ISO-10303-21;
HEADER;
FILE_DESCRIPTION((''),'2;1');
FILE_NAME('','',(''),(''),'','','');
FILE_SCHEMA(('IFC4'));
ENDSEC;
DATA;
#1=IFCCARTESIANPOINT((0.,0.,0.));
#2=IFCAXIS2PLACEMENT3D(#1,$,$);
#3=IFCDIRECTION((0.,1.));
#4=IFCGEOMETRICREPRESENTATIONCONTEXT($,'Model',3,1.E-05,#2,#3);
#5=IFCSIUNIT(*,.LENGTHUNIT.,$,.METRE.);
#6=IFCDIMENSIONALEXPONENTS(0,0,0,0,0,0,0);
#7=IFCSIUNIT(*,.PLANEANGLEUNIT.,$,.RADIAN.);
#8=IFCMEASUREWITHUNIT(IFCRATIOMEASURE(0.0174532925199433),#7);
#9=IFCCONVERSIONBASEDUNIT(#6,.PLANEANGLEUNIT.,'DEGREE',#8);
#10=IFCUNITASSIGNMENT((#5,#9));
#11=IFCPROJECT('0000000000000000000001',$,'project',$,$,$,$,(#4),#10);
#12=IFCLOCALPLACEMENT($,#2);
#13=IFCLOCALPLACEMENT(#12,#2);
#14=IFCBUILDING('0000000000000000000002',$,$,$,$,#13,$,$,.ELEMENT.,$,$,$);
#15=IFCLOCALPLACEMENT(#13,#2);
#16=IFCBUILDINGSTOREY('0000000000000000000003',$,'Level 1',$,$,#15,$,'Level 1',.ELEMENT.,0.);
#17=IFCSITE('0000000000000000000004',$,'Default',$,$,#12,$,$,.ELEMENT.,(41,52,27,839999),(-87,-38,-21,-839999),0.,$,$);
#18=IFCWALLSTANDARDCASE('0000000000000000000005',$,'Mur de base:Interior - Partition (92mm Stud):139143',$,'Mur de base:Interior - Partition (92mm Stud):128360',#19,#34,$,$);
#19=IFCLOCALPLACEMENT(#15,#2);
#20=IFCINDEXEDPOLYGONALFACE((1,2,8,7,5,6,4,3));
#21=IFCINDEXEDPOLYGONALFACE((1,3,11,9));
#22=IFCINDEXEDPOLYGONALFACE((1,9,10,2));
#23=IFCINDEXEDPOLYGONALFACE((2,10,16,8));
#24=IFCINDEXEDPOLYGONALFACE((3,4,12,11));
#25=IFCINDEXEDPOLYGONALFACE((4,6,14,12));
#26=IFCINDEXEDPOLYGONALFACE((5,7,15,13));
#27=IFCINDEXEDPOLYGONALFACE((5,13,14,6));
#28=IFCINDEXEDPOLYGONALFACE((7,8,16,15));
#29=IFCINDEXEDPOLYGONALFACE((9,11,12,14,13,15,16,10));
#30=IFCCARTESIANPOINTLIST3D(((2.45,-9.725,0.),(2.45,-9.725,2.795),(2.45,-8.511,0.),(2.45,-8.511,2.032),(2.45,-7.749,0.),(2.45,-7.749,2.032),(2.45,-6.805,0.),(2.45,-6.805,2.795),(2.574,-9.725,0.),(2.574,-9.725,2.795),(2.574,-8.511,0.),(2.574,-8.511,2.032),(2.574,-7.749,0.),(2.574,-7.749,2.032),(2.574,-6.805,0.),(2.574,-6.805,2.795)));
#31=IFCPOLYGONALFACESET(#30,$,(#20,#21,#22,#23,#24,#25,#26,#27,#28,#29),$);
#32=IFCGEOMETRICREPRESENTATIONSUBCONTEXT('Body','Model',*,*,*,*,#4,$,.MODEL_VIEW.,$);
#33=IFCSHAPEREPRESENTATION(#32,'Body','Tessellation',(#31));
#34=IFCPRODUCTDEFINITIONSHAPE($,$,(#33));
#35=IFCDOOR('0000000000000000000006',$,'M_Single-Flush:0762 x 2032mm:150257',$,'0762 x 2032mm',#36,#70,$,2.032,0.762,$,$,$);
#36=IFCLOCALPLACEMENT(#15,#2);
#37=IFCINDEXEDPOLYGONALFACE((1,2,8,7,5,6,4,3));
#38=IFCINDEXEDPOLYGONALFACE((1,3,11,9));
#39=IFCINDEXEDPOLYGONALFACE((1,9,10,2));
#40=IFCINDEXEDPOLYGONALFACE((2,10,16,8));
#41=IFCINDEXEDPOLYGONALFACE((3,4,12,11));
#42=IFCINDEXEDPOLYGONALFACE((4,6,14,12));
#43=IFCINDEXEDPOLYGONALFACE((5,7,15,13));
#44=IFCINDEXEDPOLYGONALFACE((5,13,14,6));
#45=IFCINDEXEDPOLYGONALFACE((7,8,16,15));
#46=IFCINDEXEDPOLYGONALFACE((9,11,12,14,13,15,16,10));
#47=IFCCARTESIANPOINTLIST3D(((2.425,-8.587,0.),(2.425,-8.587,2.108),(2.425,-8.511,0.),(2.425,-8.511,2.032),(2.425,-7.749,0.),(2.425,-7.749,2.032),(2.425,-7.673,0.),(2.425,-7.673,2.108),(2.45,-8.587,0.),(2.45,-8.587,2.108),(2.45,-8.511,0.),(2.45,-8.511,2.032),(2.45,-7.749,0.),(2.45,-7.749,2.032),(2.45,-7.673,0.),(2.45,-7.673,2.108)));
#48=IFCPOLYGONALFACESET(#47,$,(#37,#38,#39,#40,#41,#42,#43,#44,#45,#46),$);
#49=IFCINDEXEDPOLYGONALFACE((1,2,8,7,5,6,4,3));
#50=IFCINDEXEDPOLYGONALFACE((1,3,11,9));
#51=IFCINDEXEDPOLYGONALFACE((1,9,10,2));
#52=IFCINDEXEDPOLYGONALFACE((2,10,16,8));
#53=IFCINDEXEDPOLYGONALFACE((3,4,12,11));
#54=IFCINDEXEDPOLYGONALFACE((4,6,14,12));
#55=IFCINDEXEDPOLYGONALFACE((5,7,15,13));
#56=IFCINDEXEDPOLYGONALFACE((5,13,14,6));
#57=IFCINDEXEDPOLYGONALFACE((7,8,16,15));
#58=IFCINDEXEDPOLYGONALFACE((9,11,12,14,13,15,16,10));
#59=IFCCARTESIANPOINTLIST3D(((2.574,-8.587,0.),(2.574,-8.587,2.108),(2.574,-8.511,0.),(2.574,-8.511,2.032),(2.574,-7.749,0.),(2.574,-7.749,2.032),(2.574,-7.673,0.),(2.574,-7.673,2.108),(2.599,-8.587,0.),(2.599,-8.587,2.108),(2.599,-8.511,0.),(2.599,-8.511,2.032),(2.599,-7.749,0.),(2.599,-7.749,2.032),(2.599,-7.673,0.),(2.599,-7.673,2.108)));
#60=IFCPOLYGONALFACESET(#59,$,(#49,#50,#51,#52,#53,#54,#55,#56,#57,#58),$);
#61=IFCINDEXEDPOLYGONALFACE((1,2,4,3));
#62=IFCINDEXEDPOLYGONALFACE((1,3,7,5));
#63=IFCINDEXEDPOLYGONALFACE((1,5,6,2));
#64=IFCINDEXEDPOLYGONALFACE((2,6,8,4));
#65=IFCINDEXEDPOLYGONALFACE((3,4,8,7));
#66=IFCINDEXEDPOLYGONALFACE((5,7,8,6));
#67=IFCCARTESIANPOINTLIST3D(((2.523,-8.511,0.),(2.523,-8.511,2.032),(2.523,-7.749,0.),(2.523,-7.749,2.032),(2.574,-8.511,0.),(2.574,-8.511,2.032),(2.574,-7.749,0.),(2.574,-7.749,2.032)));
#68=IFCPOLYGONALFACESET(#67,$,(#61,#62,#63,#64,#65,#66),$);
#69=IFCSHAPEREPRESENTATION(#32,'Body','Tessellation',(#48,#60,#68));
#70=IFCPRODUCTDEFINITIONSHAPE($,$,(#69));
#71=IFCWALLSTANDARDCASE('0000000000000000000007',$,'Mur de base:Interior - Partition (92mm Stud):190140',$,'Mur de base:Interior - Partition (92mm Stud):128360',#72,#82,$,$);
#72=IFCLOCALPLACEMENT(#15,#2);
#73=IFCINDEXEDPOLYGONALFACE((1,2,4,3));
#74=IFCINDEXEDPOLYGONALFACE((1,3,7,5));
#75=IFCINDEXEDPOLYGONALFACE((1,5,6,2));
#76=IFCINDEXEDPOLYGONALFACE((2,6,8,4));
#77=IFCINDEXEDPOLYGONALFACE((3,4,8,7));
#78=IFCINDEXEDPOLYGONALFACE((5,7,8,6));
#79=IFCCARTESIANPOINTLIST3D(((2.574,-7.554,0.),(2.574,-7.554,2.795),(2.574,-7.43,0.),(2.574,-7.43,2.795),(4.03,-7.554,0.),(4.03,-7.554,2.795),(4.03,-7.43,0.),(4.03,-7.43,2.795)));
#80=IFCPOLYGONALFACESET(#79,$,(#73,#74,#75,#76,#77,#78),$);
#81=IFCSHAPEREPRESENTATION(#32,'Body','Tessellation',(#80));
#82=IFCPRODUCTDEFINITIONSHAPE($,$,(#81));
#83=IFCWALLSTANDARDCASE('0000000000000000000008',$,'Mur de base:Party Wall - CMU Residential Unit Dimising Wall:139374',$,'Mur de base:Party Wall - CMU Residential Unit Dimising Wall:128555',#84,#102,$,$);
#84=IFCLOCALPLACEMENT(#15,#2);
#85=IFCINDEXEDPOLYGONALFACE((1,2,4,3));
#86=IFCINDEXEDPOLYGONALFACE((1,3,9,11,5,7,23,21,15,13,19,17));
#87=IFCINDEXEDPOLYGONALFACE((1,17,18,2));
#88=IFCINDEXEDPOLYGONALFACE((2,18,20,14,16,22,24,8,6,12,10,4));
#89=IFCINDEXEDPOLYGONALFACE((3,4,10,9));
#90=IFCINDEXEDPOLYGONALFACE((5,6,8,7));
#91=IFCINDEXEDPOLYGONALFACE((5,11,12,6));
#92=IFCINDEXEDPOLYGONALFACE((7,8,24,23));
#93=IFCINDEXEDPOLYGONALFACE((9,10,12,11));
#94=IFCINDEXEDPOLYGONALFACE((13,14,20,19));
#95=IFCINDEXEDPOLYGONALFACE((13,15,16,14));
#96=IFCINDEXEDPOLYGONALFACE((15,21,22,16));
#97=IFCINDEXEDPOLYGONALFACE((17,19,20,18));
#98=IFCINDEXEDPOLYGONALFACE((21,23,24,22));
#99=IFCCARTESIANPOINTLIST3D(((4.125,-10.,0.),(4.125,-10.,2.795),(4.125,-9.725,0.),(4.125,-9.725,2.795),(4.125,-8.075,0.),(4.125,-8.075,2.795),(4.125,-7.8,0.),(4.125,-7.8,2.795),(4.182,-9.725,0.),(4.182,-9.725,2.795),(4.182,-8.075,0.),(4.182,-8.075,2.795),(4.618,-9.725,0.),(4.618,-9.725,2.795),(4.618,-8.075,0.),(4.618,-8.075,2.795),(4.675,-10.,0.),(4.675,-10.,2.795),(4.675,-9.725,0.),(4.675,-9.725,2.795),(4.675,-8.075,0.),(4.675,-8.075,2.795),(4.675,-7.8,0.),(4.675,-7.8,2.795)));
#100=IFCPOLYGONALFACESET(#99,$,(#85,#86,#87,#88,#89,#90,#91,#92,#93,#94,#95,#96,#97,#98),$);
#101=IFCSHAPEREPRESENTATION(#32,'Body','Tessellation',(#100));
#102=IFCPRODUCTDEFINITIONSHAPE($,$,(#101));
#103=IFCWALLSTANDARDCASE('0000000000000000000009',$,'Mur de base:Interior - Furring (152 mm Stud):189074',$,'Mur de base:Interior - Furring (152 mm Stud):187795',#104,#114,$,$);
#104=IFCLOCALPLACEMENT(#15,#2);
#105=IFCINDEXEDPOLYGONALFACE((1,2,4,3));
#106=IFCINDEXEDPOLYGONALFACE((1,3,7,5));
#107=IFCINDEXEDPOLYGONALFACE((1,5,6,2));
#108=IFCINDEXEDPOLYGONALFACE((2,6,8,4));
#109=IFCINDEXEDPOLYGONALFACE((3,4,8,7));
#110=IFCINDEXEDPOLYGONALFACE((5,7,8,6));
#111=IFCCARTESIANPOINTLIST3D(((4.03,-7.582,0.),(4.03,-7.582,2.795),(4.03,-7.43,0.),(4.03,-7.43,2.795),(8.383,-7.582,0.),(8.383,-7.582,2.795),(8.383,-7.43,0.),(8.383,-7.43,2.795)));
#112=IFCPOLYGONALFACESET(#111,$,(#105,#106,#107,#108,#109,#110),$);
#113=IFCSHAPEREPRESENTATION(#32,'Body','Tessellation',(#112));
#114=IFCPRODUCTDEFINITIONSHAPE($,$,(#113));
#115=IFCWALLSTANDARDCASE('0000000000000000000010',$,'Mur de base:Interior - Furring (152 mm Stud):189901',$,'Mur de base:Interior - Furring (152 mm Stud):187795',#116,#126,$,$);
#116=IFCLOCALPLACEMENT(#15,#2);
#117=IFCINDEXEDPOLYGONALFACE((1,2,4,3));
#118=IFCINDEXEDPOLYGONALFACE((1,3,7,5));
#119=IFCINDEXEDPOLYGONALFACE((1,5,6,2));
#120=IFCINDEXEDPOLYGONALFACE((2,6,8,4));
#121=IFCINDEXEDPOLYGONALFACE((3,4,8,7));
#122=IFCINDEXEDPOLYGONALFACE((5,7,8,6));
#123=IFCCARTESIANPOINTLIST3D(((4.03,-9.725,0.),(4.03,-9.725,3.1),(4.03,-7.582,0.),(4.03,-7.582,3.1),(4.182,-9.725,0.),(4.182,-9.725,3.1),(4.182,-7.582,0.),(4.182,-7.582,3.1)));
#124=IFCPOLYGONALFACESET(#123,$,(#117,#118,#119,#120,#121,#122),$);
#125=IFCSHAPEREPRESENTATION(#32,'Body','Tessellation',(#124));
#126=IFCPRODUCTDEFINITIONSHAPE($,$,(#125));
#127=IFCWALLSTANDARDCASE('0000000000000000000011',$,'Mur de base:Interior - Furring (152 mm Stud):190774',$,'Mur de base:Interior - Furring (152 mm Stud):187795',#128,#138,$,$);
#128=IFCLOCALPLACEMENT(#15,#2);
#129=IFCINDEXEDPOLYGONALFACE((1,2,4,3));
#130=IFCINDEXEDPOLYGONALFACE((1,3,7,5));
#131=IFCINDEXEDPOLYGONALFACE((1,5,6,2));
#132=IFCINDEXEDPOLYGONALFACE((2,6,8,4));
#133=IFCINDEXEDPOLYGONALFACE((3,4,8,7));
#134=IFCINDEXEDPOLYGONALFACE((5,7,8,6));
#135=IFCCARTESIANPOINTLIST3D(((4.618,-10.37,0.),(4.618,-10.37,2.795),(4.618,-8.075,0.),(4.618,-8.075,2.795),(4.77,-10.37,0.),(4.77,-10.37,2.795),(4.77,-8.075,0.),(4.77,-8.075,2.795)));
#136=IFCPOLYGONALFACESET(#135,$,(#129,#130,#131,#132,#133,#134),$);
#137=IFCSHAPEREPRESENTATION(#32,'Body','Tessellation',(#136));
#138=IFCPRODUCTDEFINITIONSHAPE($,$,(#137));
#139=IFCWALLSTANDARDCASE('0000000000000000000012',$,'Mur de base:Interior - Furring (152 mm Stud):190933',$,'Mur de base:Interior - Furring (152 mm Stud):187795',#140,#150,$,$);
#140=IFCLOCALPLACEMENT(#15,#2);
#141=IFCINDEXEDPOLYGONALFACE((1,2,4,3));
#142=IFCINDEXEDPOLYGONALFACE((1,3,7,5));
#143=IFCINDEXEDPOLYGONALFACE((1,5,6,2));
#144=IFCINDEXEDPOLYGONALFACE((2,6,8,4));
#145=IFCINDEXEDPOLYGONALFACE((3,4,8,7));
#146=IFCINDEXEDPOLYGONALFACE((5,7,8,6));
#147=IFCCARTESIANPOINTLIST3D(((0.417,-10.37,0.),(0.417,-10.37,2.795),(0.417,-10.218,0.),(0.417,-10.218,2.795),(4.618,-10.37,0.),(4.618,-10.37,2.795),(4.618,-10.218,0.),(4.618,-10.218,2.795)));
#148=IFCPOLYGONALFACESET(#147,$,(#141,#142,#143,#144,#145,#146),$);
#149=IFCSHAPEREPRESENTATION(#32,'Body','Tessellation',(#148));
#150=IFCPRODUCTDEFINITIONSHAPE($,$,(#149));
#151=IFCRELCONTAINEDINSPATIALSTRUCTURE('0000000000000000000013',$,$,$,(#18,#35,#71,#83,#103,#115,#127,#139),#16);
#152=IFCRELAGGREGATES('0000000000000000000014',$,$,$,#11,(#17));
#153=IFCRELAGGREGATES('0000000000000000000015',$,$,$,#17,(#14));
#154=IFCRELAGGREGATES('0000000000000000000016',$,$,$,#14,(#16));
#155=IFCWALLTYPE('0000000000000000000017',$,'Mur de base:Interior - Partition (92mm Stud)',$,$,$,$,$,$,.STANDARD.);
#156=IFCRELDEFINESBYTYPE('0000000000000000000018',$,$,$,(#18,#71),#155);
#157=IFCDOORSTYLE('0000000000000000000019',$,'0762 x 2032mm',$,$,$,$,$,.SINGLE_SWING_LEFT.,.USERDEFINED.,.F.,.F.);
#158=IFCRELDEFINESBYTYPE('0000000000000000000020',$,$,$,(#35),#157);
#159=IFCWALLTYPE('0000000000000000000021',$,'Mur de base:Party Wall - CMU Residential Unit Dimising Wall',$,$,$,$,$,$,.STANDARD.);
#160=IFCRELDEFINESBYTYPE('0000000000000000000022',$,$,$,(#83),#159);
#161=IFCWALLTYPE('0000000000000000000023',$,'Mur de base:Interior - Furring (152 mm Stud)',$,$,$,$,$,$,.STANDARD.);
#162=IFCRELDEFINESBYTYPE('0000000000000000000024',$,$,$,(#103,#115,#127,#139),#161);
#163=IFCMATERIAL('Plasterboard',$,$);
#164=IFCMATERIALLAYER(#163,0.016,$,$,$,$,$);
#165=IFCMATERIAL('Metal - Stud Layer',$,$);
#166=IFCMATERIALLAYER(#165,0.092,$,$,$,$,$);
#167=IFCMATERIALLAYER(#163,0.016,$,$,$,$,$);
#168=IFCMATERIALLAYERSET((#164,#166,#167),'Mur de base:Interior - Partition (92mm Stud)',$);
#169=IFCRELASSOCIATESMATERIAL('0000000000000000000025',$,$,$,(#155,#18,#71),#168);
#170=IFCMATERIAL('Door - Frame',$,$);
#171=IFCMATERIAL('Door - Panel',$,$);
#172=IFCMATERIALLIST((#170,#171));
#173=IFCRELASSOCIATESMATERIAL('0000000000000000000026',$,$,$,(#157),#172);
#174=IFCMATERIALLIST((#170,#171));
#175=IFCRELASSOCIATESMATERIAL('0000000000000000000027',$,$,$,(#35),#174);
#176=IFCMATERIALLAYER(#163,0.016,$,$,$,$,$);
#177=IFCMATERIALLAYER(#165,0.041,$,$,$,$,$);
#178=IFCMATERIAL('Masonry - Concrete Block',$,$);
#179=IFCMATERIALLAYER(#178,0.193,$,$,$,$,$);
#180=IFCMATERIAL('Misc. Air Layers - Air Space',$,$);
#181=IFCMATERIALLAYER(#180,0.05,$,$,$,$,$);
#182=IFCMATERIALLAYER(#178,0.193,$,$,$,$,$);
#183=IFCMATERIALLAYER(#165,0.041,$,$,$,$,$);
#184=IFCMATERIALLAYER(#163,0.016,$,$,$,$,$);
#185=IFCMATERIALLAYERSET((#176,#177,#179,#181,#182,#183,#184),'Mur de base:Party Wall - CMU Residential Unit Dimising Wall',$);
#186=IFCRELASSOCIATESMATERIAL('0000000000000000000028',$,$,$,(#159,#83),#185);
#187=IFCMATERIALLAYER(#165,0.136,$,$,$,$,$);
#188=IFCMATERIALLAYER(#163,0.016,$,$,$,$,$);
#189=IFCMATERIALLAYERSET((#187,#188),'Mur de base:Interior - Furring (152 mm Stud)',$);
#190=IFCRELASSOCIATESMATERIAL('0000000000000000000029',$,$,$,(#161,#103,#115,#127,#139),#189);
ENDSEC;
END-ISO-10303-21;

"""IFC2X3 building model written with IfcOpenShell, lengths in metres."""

from ifc_helpers import new_model, entity, si_unit, converted_unit, direction, frame, frame_2d, origin, place, context, subcontext, project, spatial, polyline, rectangle, outline, extrude, clip, bounded_halfspace, source, transform, mapped, material, material_list, layer, layer_set, layer_usage, type_object, type_shapes, element, fill, save


model = new_model("IFC2X3")

# Units and contexts
model_context = context("Model", 3, precision=1e-05, world=origin(), true_north=direction((0.0, 1.0)))
body_context = subcontext(model_context, "Body", "Model", "MODEL_VIEW")
ifc_project = project(units=[si_unit("LENGTHUNIT", "METRE"), converted_unit("PLANEANGLEUNIT", "DEGREE", entity("IfcRatioMeasure", 0.0174532925199433), si_unit("PLANEANGLEUNIT", "RADIAN"), dimensions=[0, 0, 0, 0, 0, 0, 0])], contexts=[model_context])

# Site, building, storey
site_placement = place(None, origin())
site = spatial("IfcSite", under=ifc_project, at=site_placement, Name="Default", CompositionType="ELEMENT", RefLatitude=(41, 52, 27, 839999), RefLongitude=(-87, -38, -21, -839999), RefElevation=0.0)
building_placement = place(site_placement, origin())
building = spatial("IfcBuilding", under=site, at=building_placement, CompositionType="ELEMENT")
storey_placement = place(building_placement, origin())
storey = spatial("IfcBuildingStorey", under=building, at=storey_placement, Name="Level 1", LongName="Level 1", CompositionType="ELEMENT", Elevation=0.0)

# Wall, opening, door
ifc_material_1 = material(Name="Plasterboard")
ifc_layer_1 = layer(ifc_material_1, 0.016)
ifc_material_2 = material(Name="Metal - Stud Layer")
ifc_layer_2 = layer(ifc_material_2, 0.092)
ifc_layer_3 = layer(ifc_material_1, 0.016)
ifc_layer_set_1 = layer_set([ifc_layer_1, ifc_layer_2, ifc_layer_3], Name="Mur de base:Interior - Partition (92mm Stud)")
ifc_layer_usage_1 = layer_usage(ifc_layer_set_1, "AXIS2", "NEGATIVE", 0.062)
wall_type_1 = type_object("IfcWallType", Name="Mur de base:Interior - Partition (92mm Stud)", PredefinedType="STANDARD", material=ifc_layer_set_1)
wall_1_placement = place(storey_placement, frame((2.512, -6.805, 0.0), z_axis=(0.0, 0.0, 1.0), x_axis=(0.0, -1.0, 0.0)))
wall_1 = element("IfcWallStandardCase", 1, at=wall_1_placement, inside=storey, type_object=wall_type_1, material=ifc_layer_usage_1, Name="Mur de base:Interior - Partition (92mm Stud):139143", ObjectType="Mur de base:Interior - Partition (92mm Stud):128360", context=body_context, shape_type="SweptSolid", body=[
    extrude(rectangle(XDim=2.92, YDim=0.124, at=frame_2d((1.46, 0.0), x_axis=(-1.0, 0.0))), origin(), (0.0, 0.0, 1.0), 2.795),
])
opening_1_placement = place(wall_1_placement, frame((0.944, -0.062, 0.0)))
opening_1 = element("IfcOpeningElement", 2, at=opening_1_placement, cuts=wall_1, ObjectType="Opening", context=body_context, shape_type="SweptSolid", body=[
    extrude(rectangle(XDim=0.762, YDim=2.032, at=frame_2d((1.016, 0.381), x_axis=(0.0, -1.0))), frame((0.0, 0.0, 0.0), z_axis=(0.0, 1.0, 0.0), x_axis=(0.0, 0.0, 1.0)), (0.0, 0.0, 1.0), 0.124),
])
ifc_material_3 = material(Name="Door - Frame")
ifc_material_4 = material(Name="Door - Panel")
ifc_material_list_1 = material_list([ifc_material_3, ifc_material_4])
ifc_material_list_2 = material_list([ifc_material_3, ifc_material_4])
door_style = type_object("IfcDoorStyle", Name="0762 x 2032mm", ConstructionType="USERDEFINED", OperationType="SINGLE_SWING_LEFT", ParameterTakesPrecedence=False, Sizeable=False, material=ifc_material_list_2)
shared_shape_1 = source(origin(), body_context, "Body", "SweptSolid", [
    extrude(outline(polyline([(-1.073, -0.457), (1.035, -0.457), (1.035, -0.381), (-0.997, -0.381), (-0.997, 0.381), (1.035, 0.381), (1.035, 0.457), (-1.073, 0.457), (-1.073, -0.457)])), frame((0.381, 0.0, 1.035), z_axis=(0.0, -1.0, 0.0), x_axis=(0.0, 0.0, -1.0)), (0.0, 0.0, 1.0), 0.025),
    extrude(outline(polyline([(-0.457, -1.073), (0.457, -1.073), (0.457, 1.035), (0.381, 1.035), (0.381, -0.997), (-0.381, -0.997), (-0.381, 1.035), (-0.457, 1.035), (-0.457, -1.073)])), frame((0.381, 0.149, 1.035), z_axis=(0.0, -1.0, 0.0), x_axis=(-1.0, 0.0, 0.0)), (0.0, 0.0, 1.0), 0.025),
    extrude(rectangle(XDim=0.762, YDim=0.051, at=frame_2d((0.0, 0.0), x_axis=(1.0, 0.0))), frame((0.381, 0.0985, 0.0)), (0.0, 0.0, 1.0), 2.032),
])
type_shapes(door_style, [shared_shape_1])
door_placement = place(opening_1_placement, origin())
door = element("IfcDoor", 3, at=door_placement, inside=storey, type_object=door_style, material=ifc_material_list_1, Name="M_Single-Flush:0762 x 2032mm:150257", ObjectType="0762 x 2032mm", OverallHeight=2.032, OverallWidth=0.762, context=body_context, shape_type="MappedRepresentation", body=[
    mapped(shared_shape_1, transform((0.0, 0.0, 0.0), scale=1.0)),
])
fill(opening_1, door)

# Walls
ifc_layer_usage_2 = layer_usage(ifc_layer_set_1, "AXIS2", "NEGATIVE", 0.062)
wall_2_placement = place(storey_placement, frame((4.03, -7.492, 0.0), z_axis=(0.0, 0.0, 1.0), x_axis=(-1.0, 0.0, 0.0)))
element("IfcWallStandardCase", 4, at=wall_2_placement, inside=storey, type_object=wall_type_1, material=ifc_layer_usage_2, Name="Mur de base:Interior - Partition (92mm Stud):190140", ObjectType="Mur de base:Interior - Partition (92mm Stud):128360", context=body_context, shape_type="SweptSolid", body=[
    extrude(rectangle(XDim=1.456, YDim=0.124, at=frame_2d((0.728, 0.0), x_axis=(-1.0, 0.0))), origin(), (0.0, 0.0, 1.0), 2.795),
])
ifc_layer_4 = layer(ifc_material_1, 0.016)
ifc_layer_5 = layer(ifc_material_2, 0.041)
ifc_material_5 = material(Name="Masonry - Concrete Block")
ifc_layer_6 = layer(ifc_material_5, 0.193)
ifc_material_6 = material(Name="Misc. Air Layers - Air Space")
ifc_layer_7 = layer(ifc_material_6, 0.05)
ifc_layer_8 = layer(ifc_material_5, 0.193)
ifc_layer_9 = layer(ifc_material_2, 0.041)
ifc_layer_10 = layer(ifc_material_1, 0.016)
ifc_layer_set_2 = layer_set([ifc_layer_4, ifc_layer_5, ifc_layer_6, ifc_layer_7, ifc_layer_8, ifc_layer_9, ifc_layer_10], Name="Mur de base:Party Wall - CMU Residential Unit Dimising Wall")
wall_type_2 = type_object("IfcWallType", Name="Mur de base:Party Wall - CMU Residential Unit Dimising Wall", PredefinedType="STANDARD", material=ifc_layer_set_2)
ifc_layer_usage_3 = layer_usage(ifc_layer_set_2, "AXIS2", "NEGATIVE", 0.275)
wall_3_placement = place(storey_placement, frame((4.4, -10.0, 0.0), z_axis=(0.0, 0.0, 1.0), x_axis=(0.0, 1.0, 0.0)))
element("IfcWallStandardCase", 5, at=wall_3_placement, inside=storey, type_object=wall_type_2, material=ifc_layer_usage_3, Name="Mur de base:Party Wall - CMU Residential Unit Dimising Wall:139374", ObjectType="Mur de base:Party Wall - CMU Residential Unit Dimising Wall:128555", context=body_context, shape_type="Clipping", body=[
    clip(clip(extrude(rectangle(XDim=2.2, YDim=0.55, at=frame_2d((1.1, 0.0), x_axis=(-1.0, 0.0))), origin(), (0.0, 0.0, 1.0), 2.795), bounded_halfspace(frame((1.925, 0.218, 0.0), z_axis=(0.0, -1.0, 0.0), x_axis=(1.0, 0.0, 0.0)), True, frame((1.925, 0.218, 0.0), z_axis=(0.0, -1.0, 0.0), x_axis=(1.0, 0.0, 0.0)), polyline([(0.0, 0.0), (0.0, 2.795), (-1.65, 2.795), (-1.65, 0.0), (0.0, 0.0)]))), bounded_halfspace(frame((0.275, -0.218, 0.0), z_axis=(0.0, 1.0, 0.0), x_axis=(-1.0, 0.0, 0.0)), True, frame((0.275, -0.218, 0.0), z_axis=(0.0, 1.0, 0.0), x_axis=(-1.0, 0.0, 0.0)), polyline([(0.0, 0.0), (0.0, 2.795), (-1.65, 2.795), (-1.65, 0.0), (0.0, 0.0)]))),
])
ifc_layer_11 = layer(ifc_material_2, 0.136)
ifc_layer_12 = layer(ifc_material_1, 0.016)
ifc_layer_set_3 = layer_set([ifc_layer_11, ifc_layer_12], Name="Mur de base:Interior - Furring (152 mm Stud)")
ifc_layer_usage_4 = layer_usage(ifc_layer_set_3, "AXIS2", "NEGATIVE", 0.076)
wall_type_3 = type_object("IfcWallType", Name="Mur de base:Interior - Furring (152 mm Stud)", PredefinedType="STANDARD", material=ifc_layer_set_3)
wall_4_placement = place(storey_placement, frame((8.383, -7.506, 0.0), z_axis=(0.0, 0.0, 1.0), x_axis=(-1.0, 0.0, 0.0)))
element("IfcWallStandardCase", 6, at=wall_4_placement, inside=storey, type_object=wall_type_3, material=ifc_layer_usage_4, Name="Mur de base:Interior - Furring (152 mm Stud):189074", ObjectType="Mur de base:Interior - Furring (152 mm Stud):187795", context=body_context, shape_type="Clipping", body=[
    clip(extrude(rectangle(XDim=4.353, YDim=0.152, at=frame_2d((2.1765, 0.0), x_axis=(-1.0, 0.0))), origin(), (0.0, 0.0, 1.0), 2.795), bounded_halfspace(frame((0.0, -0.076, 2.795), z_axis=(0.0, 0.0, -1.0), x_axis=(0.0, 1.0, 0.0)), True, frame((0.0, -0.076, 2.795)), polyline([(0.0, 0.0), (3.708, 0.0), (3.708, 0.152), (0.0, 0.152), (0.0, 0.0)]))),
])
ifc_layer_usage_5 = layer_usage(ifc_layer_set_3, "AXIS2", "POSITIVE", -0.076)
wall_5_placement = place(storey_placement, frame((4.106, -9.725, 0.0), z_axis=(0.0, 0.0, 1.0), x_axis=(0.0, 1.0, 0.0)))
element("IfcWallStandardCase", 7, at=wall_5_placement, inside=storey, type_object=wall_type_3, material=ifc_layer_usage_5, Name="Mur de base:Interior - Furring (152 mm Stud):189901", ObjectType="Mur de base:Interior - Furring (152 mm Stud):187795", context=body_context, shape_type="SweptSolid", body=[
    extrude(rectangle(XDim=2.143, YDim=0.152, at=frame_2d((1.0715, 0.0), x_axis=(-1.0, 0.0))), origin(), (0.0, 0.0, 1.0), 3.1),
])
ifc_layer_usage_6 = layer_usage(ifc_layer_set_3, "AXIS2", "POSITIVE", -0.076)
wall_6_placement = place(storey_placement, frame((4.694, -8.075, 0.0), z_axis=(0.0, 0.0, 1.0), x_axis=(0.0, -1.0, 0.0)))
element("IfcWallStandardCase", 8, at=wall_6_placement, inside=storey, type_object=wall_type_3, material=ifc_layer_usage_6, Name="Mur de base:Interior - Furring (152 mm Stud):190774", ObjectType="Mur de base:Interior - Furring (152 mm Stud):187795", context=body_context, shape_type="SweptSolid", body=[
    extrude(rectangle(XDim=2.295, YDim=0.152, at=frame_2d((1.1475, 0.0), x_axis=(-1.0, 0.0))), origin(), (0.0, 0.0, 1.0), 2.795),
])
ifc_layer_usage_7 = layer_usage(ifc_layer_set_3, "AXIS2", "NEGATIVE", 0.076)
wall_7_placement = place(storey_placement, frame((0.417, -10.294, 0.0)))
element("IfcWallStandardCase", 9, at=wall_7_placement, inside=storey, type_object=wall_type_3, material=ifc_layer_usage_7, Name="Mur de base:Interior - Furring (152 mm Stud):190933", ObjectType="Mur de base:Interior - Furring (152 mm Stud):187795", context=body_context, shape_type="SweptSolid", body=[
    extrude(rectangle(XDim=4.201, YDim=0.152, at=frame_2d((2.1005, 0.0), x_axis=(-1.0, 0.0))), origin(), (0.0, 0.0, 1.0), 2.795),
])

save(model, "model.ifc")
